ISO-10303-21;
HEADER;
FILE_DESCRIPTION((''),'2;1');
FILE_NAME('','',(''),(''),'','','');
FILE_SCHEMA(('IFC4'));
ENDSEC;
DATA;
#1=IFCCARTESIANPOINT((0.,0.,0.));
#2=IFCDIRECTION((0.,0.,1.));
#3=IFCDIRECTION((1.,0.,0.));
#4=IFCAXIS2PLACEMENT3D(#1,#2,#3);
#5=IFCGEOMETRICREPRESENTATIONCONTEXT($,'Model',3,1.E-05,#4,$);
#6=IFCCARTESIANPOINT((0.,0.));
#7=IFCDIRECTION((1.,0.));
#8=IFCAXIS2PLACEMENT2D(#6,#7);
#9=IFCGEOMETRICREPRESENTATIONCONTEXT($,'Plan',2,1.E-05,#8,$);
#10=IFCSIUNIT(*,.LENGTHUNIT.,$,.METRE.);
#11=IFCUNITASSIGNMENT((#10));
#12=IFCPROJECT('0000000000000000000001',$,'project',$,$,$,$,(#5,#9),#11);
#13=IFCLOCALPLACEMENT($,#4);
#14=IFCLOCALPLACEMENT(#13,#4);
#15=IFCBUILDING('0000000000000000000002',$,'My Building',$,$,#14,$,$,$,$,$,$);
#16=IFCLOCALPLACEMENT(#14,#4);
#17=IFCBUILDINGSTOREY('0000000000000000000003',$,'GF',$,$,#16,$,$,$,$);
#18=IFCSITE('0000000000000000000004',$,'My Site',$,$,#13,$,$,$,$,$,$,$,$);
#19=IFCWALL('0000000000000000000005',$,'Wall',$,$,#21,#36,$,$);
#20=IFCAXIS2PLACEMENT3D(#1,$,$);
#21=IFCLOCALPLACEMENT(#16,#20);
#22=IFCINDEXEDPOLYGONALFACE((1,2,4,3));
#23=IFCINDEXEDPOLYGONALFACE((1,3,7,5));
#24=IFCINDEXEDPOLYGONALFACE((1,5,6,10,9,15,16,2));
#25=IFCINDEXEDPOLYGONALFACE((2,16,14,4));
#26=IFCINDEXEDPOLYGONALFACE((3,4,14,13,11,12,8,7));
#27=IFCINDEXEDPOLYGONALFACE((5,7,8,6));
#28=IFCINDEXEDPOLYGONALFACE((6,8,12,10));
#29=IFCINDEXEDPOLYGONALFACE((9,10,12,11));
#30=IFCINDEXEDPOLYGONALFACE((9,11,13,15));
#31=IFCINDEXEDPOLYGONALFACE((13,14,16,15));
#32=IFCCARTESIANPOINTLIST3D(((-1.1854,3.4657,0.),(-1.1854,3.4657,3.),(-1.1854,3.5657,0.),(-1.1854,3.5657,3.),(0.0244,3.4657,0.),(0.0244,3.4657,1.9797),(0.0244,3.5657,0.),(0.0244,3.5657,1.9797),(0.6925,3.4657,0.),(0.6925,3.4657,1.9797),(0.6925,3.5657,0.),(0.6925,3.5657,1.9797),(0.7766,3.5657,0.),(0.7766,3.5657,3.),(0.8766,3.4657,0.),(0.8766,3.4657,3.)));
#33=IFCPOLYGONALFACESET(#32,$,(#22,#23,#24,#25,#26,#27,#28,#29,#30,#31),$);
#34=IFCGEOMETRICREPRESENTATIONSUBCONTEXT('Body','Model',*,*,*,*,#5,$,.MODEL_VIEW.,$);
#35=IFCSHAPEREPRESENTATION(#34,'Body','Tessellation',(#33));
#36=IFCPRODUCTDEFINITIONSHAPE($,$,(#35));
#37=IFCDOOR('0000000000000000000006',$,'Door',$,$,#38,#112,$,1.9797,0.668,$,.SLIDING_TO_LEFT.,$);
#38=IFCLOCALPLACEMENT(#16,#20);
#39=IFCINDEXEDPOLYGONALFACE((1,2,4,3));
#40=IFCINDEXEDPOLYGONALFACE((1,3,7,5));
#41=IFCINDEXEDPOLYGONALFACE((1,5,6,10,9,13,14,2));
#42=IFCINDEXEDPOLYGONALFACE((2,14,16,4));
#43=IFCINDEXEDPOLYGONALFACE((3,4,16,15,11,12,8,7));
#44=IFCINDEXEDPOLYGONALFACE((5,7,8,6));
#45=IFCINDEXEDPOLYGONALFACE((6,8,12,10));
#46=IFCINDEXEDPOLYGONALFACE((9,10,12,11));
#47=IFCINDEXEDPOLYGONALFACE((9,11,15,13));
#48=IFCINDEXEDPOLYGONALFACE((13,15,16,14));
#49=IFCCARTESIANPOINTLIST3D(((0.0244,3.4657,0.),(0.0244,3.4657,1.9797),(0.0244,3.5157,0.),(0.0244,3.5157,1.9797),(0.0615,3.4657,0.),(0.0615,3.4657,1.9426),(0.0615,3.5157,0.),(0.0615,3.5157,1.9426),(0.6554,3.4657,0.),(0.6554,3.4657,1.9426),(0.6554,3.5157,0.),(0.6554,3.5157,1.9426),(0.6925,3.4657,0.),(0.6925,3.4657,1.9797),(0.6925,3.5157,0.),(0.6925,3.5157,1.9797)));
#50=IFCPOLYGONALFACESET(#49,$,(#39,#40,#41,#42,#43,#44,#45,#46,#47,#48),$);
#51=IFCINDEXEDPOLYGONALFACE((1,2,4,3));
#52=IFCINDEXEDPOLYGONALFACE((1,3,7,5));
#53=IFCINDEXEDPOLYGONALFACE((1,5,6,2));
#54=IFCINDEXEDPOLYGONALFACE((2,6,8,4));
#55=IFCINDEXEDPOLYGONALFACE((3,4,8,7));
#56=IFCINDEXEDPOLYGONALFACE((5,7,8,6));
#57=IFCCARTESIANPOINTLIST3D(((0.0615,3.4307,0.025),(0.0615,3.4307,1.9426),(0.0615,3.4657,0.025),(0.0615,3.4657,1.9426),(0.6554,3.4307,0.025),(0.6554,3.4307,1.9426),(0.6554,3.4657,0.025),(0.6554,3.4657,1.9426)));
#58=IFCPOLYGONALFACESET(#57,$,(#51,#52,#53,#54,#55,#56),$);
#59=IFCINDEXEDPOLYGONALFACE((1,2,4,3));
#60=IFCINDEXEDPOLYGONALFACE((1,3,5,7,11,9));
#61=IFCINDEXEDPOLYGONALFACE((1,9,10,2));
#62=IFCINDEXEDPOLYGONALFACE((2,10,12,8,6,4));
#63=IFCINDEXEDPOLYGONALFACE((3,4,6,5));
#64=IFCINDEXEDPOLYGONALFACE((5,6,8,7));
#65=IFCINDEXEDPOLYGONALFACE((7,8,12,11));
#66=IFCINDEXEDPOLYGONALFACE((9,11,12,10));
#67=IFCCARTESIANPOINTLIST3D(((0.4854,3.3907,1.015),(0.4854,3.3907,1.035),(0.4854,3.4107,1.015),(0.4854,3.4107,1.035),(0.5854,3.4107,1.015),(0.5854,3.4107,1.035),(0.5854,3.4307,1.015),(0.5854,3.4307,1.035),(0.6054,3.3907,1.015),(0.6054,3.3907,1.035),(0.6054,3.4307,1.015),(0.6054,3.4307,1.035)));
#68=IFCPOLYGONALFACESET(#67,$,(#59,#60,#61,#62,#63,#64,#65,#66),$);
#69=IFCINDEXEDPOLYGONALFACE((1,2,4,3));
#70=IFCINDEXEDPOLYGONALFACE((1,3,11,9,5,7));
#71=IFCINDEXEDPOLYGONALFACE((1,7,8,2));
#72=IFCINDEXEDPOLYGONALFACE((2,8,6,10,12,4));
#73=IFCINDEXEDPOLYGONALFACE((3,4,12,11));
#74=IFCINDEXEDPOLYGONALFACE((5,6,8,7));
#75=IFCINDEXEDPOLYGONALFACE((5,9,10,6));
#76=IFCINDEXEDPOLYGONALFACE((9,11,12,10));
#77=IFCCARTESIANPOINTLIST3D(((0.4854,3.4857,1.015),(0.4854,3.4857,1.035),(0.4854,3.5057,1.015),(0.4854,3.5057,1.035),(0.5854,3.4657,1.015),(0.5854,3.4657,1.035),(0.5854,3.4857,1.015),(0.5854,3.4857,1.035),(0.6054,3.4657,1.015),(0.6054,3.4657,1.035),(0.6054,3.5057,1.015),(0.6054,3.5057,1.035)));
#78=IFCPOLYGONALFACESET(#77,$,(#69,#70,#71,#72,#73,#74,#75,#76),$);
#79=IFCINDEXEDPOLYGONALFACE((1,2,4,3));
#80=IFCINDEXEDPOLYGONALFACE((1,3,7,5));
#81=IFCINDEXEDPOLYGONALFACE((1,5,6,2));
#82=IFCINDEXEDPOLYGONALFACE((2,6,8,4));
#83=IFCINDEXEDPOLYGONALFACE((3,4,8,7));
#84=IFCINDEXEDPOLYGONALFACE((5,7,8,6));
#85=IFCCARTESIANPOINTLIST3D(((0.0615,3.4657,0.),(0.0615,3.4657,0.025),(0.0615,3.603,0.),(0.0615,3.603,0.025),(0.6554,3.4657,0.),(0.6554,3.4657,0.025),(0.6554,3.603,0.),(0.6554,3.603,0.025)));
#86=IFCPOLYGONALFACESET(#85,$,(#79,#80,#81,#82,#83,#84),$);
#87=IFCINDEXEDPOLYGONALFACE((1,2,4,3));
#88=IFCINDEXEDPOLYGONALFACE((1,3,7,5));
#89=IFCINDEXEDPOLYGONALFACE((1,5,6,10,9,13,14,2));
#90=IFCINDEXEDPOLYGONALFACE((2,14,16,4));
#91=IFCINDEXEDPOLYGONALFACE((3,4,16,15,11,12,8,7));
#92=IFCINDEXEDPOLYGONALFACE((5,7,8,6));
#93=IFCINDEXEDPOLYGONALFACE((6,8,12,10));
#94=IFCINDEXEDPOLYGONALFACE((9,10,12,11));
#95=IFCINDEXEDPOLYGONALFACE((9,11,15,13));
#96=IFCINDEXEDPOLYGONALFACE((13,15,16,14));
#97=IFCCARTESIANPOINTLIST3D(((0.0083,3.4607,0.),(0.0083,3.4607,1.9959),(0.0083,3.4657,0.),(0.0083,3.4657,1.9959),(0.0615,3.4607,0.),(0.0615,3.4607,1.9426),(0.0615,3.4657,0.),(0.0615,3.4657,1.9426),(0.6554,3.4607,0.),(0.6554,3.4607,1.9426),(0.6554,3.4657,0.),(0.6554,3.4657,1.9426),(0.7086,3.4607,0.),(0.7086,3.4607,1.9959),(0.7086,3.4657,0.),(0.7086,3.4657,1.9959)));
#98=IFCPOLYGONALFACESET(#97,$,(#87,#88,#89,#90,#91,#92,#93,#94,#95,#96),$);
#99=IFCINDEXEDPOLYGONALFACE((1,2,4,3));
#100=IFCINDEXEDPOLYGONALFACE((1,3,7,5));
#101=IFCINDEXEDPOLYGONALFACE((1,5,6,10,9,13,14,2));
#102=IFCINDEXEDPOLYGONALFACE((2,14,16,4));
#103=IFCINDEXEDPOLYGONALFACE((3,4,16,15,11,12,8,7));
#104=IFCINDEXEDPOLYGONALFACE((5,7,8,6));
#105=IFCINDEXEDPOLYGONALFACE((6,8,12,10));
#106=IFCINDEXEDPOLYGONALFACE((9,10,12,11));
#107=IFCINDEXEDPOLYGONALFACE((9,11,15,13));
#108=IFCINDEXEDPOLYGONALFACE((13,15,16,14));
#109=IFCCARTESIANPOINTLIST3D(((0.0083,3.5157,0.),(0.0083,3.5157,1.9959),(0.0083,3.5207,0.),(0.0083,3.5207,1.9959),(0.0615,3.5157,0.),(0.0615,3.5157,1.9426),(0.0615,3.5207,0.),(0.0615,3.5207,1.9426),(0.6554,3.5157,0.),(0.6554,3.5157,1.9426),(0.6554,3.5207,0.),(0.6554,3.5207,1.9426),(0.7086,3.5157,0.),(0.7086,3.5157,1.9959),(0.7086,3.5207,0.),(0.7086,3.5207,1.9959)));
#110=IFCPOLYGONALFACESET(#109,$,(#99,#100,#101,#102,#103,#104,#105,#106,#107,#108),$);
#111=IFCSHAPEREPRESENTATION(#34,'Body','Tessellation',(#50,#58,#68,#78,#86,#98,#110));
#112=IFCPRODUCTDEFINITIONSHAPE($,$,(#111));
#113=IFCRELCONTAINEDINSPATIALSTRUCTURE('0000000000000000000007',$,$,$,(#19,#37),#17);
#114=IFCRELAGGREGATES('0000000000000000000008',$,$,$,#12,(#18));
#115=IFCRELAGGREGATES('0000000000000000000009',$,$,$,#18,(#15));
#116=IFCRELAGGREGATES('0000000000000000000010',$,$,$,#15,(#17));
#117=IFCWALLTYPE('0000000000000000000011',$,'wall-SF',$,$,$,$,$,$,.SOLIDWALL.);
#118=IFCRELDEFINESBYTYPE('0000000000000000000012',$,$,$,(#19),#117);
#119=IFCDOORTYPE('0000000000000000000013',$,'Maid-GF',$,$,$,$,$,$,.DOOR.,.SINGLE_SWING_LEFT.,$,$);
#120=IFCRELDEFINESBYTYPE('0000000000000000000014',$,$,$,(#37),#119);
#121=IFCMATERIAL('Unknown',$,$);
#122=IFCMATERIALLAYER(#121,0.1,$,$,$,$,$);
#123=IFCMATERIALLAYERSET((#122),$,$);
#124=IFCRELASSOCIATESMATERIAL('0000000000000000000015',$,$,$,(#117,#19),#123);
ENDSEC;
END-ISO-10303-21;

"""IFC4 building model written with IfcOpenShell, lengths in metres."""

from ifc_helpers import new_model, entity, si_unit, frame, origin_with_axes, origin_2d_with_axis, place, context, subcontext, project, spatial, line, indexed_curve, outline, extrude, shape, source, transform, mapped, material, layer, layer_set, layer_usage, type_object, type_shapes, element, fill, save


model = new_model("IFC4")

# Units and contexts
model_context = context("Model", 3, precision=1e-05, world=origin_with_axes())
plan_context = context("Plan", 2, precision=1e-05, world=origin_2d_with_axis())
body_context_1 = subcontext(model_context, "Body", "Model", "MODEL_VIEW")
body_context_2 = subcontext(plan_context, "Body", "Plan", "PLAN_VIEW")
ifc_project = project(units=[si_unit("LENGTHUNIT", "METRE")], contexts=[model_context, plan_context])

# Site, building, storey
site_placement = place(None, origin_with_axes())
site = spatial("IfcSite", under=ifc_project, at=site_placement, Name="My Site")
building_placement = place(site_placement, origin_with_axes())
building = spatial("IfcBuilding", under=site, at=building_placement, Name="My Building")
storey_placement = place(building_placement, origin_with_axes())
storey = spatial("IfcBuildingStorey", under=building, at=storey_placement, Name="GF")

# Shared definitions
ifc_material = material(Name="Unknown")

# Shared definitions
ifc_layer_1 = layer(ifc_material, 0.1)
ifc_layer_set_1 = layer_set([ifc_layer_1])
wall_type = type_object("IfcWallType", Name="wall-SF", PredefinedType="SOLIDWALL", material=ifc_layer_set_1)

# Wall, opening, door
ifc_layer_usage_1 = layer_usage(ifc_layer_set_1, "AXIS2", "POSITIVE", 0.0)
wall_1_placement = place(storey_placement, frame((0.7766, 3.5657, 0.0), z_axis=(0.0, 0.0, 1.0), x_axis=(-1.0, 0.0, 0.0)))
wall_1 = element("IfcWall", 1, at=wall_1_placement, inside=storey, type_object=wall_type, material=ifc_layer_usage_1, Name="Wall", context=body_context_1, shape_type="SweptSolid", body=[
    extrude(outline(indexed_curve([(0.0, 0.0), (-0.1, 0.1), (1.962, 0.1), (1.962, 0.0)], segments=[line(1, 2, 3, 4, 1)])), origin_with_axes(), (0.0, 0.0, 1.0), 3.0),
])
shared_shape_1 = source(origin_with_axes(), body_context_1, "Body", "SweptSolid", [
    extrude(outline(indexed_curve([(0.0, 0.0), (0.668, 0.0), (0.668, 1.9797), (0.0, 1.9797)], segments=[line(1, 2, 3, 4, 1)])), frame((0.0, -0.6, 0.0), z_axis=(0.0, -1.0, 0.0), x_axis=(1.0, 0.0, 0.0)), (0.0, 0.0, -1.0), 1.2),
])
opening_1_placement = place(wall_1_placement, frame((0.7522, 0.1, 0.0), z_axis=(0.0, 0.0, 1.0), x_axis=(-1.0, 0.0, 0.0)))
opening_1 = element("IfcOpeningElement", 2, at=opening_1_placement, cuts=wall_1, PredefinedType="OPENING", context=body_context_1, shape_type="MappedRepresentation", body=[
    mapped(shared_shape_1, transform((0.0, 0.0, 0.0), x_axis=(1.0, 0.0, 0.0), y_axis=(0.0, 1.0, 0.0), z_axis=(0.0, 0.0, 1.0), scale=1.0)),
])
door_type_1 = type_object("IfcDoorType", Name="Maid-GF", OperationType="SINGLE_SWING_LEFT", PredefinedType="DOOR")
shared_shape_2 = source(origin_with_axes(), body_context_1, "Body", "SweptSolid", [
    extrude(outline(indexed_curve([(0.0, 0.0), (0.0, 1.9797), (0.668, 1.9797), (0.668, 0.0), (0.6309, 0.0), (0.6309, 1.9426), (0.0371, 1.9426), (0.0371, 0.0)], segments=[line(1, 2, 3, 4, 5, 6, 7, 8, 1)])), frame((0.0, 0.0, 0.0), z_axis=(0.0, -1.0, 0.0), x_axis=(1.0, 0.0, 0.0)), (0.0, 0.0, -1.0), 0.05),
    extrude(outline(indexed_curve([(0.0, 0.0), (0.5938, 0.0), (0.5938, 0.035), (0.0, 0.035)], segments=[line(1, 2, 3, 4, 1)])), frame((0.0371, -0.035, 0.025), z_axis=(0.0, 0.0, 1.0), x_axis=(1.0, 0.0, 0.0)), (0.0, 0.0, 1.0), 1.9176),
    extrude(outline(indexed_curve([(0.0, 0.0), (0.0, -0.04), (-0.12, -0.04), (-0.12, -0.02), (-0.02, -0.02), (-0.02, 0.0)], segments=[line(1, 2, 3, 4, 5, 6, 1)])), frame((0.5809, -0.035, 1.015), z_axis=(0.0, 0.0, 1.0), x_axis=(1.0, 0.0, 0.0)), (0.0, 0.0, 1.0), 0.02),
    extrude(outline(indexed_curve([(0.0, 0.0), (0.0, 0.04), (-0.12, 0.04), (-0.12, 0.02), (-0.02, 0.02), (-0.02, 0.0)], segments=[line(1, 2, 3, 4, 5, 6, 1)])), frame((0.5809, 0.0, 1.015), z_axis=(0.0, 0.0, 1.0), x_axis=(1.0, 0.0, 0.0)), (0.0, 0.0, 1.0), 0.02),
    extrude(outline(indexed_curve([(0.0, 0.0), (0.5938, 0.0), (0.5938, 0.1372), (0.0, 0.1372)], segments=[line(1, 2, 3, 4, 1)])), frame((0.0371, 0.0, 0.0), z_axis=(0.0, 0.0, 1.0), x_axis=(1.0, 0.0, 0.0)), (0.0, 0.0, 1.0), 0.025),
    extrude(outline(indexed_curve([(0.0, 0.0), (0.0, 1.9959), (0.7003, 1.9959), (0.7003, 0.0), (0.6471, 0.0), (0.6471, 1.9426), (0.0532, 1.9426), (0.0532, 0.0)], segments=[line(1, 2, 3, 4, 5, 6, 7, 8, 1)])), frame((-0.0162, -0.005, 0.0), z_axis=(0.0, -1.0, 0.0), x_axis=(1.0, 0.0, 0.0)), (0.0, 0.0, -1.0), 0.005),
    extrude(outline(indexed_curve([(0.0, 0.0), (0.0, 1.9959), (0.7003, 1.9959), (0.7003, 0.0), (0.6471, 0.0), (0.6471, 1.9426), (0.0532, 1.9426), (0.0532, 0.0)], segments=[line(1, 2, 3, 4, 5, 6, 7, 8, 1)])), frame((-0.0162, 0.05, 0.0), z_axis=(0.0, -1.0, 0.0), x_axis=(1.0, 0.0, 0.0)), (0.0, 0.0, -1.0), 0.005),
])
shared_shape_3 = source(origin_with_axes(), body_context_2, "Body", "Curve2D", [
    entity("IfcIndexedPolyCurve", entity("IfcCartesianPointList2D", [[0.0, 0.0], [0.0371, 0.0], [0.0371, 0.05], [0.0, 0.05]]), [entity("IfcLineIndex", [1, 2, 3, 4, 1])]),
    entity("IfcIndexedPolyCurve", entity("IfcCartesianPointList2D", [[0.668, 0.0], [0.6309, 0.0], [0.6309, 0.05], [0.668, 0.05]]), [entity("IfcLineIndex", [1, 2, 3, 4, 1])]),
    entity("IfcIndexedPolyCurve", entity("IfcCartesianPointList2D", [[-0.2598, -0.035], [0.334, -0.035], [0.334, 0.0], [-0.2598, 0.0]]), [entity("IfcLineIndex", [1, 2, 3, 4, 1])]),
])
type_shapes(door_type_1, [shared_shape_2, shared_shape_3])
door_1_placement = place(opening_1_placement, origin_with_axes())
door_1 = element("IfcDoor", 3, at=door_1_placement, inside=storey, type_object=door_type_1, Name="Door", OperationType="SLIDING_TO_LEFT", OverallHeight=1.9797, OverallWidth=0.668, shapes=[
    shape(body_context_1, "Body", "MappedRepresentation", [mapped(shared_shape_2, transform((0.0, 0.0, 0.0), x_axis=(1.0, 0.0, 0.0), y_axis=(0.0, 1.0, 0.0), z_axis=(0.0, 0.0, 1.0), scale=1.0))]),
    shape(body_context_2, "Body", "MappedRepresentation", [mapped(shared_shape_3, transform((0.0, 0.0, 0.0), x_axis=(1.0, 0.0, 0.0), y_axis=(0.0, 1.0, 0.0), z_axis=(0.0, 0.0, 1.0), scale=1.0))]),
])
fill(opening_1, door_1)

save(model, "model.ifc")
